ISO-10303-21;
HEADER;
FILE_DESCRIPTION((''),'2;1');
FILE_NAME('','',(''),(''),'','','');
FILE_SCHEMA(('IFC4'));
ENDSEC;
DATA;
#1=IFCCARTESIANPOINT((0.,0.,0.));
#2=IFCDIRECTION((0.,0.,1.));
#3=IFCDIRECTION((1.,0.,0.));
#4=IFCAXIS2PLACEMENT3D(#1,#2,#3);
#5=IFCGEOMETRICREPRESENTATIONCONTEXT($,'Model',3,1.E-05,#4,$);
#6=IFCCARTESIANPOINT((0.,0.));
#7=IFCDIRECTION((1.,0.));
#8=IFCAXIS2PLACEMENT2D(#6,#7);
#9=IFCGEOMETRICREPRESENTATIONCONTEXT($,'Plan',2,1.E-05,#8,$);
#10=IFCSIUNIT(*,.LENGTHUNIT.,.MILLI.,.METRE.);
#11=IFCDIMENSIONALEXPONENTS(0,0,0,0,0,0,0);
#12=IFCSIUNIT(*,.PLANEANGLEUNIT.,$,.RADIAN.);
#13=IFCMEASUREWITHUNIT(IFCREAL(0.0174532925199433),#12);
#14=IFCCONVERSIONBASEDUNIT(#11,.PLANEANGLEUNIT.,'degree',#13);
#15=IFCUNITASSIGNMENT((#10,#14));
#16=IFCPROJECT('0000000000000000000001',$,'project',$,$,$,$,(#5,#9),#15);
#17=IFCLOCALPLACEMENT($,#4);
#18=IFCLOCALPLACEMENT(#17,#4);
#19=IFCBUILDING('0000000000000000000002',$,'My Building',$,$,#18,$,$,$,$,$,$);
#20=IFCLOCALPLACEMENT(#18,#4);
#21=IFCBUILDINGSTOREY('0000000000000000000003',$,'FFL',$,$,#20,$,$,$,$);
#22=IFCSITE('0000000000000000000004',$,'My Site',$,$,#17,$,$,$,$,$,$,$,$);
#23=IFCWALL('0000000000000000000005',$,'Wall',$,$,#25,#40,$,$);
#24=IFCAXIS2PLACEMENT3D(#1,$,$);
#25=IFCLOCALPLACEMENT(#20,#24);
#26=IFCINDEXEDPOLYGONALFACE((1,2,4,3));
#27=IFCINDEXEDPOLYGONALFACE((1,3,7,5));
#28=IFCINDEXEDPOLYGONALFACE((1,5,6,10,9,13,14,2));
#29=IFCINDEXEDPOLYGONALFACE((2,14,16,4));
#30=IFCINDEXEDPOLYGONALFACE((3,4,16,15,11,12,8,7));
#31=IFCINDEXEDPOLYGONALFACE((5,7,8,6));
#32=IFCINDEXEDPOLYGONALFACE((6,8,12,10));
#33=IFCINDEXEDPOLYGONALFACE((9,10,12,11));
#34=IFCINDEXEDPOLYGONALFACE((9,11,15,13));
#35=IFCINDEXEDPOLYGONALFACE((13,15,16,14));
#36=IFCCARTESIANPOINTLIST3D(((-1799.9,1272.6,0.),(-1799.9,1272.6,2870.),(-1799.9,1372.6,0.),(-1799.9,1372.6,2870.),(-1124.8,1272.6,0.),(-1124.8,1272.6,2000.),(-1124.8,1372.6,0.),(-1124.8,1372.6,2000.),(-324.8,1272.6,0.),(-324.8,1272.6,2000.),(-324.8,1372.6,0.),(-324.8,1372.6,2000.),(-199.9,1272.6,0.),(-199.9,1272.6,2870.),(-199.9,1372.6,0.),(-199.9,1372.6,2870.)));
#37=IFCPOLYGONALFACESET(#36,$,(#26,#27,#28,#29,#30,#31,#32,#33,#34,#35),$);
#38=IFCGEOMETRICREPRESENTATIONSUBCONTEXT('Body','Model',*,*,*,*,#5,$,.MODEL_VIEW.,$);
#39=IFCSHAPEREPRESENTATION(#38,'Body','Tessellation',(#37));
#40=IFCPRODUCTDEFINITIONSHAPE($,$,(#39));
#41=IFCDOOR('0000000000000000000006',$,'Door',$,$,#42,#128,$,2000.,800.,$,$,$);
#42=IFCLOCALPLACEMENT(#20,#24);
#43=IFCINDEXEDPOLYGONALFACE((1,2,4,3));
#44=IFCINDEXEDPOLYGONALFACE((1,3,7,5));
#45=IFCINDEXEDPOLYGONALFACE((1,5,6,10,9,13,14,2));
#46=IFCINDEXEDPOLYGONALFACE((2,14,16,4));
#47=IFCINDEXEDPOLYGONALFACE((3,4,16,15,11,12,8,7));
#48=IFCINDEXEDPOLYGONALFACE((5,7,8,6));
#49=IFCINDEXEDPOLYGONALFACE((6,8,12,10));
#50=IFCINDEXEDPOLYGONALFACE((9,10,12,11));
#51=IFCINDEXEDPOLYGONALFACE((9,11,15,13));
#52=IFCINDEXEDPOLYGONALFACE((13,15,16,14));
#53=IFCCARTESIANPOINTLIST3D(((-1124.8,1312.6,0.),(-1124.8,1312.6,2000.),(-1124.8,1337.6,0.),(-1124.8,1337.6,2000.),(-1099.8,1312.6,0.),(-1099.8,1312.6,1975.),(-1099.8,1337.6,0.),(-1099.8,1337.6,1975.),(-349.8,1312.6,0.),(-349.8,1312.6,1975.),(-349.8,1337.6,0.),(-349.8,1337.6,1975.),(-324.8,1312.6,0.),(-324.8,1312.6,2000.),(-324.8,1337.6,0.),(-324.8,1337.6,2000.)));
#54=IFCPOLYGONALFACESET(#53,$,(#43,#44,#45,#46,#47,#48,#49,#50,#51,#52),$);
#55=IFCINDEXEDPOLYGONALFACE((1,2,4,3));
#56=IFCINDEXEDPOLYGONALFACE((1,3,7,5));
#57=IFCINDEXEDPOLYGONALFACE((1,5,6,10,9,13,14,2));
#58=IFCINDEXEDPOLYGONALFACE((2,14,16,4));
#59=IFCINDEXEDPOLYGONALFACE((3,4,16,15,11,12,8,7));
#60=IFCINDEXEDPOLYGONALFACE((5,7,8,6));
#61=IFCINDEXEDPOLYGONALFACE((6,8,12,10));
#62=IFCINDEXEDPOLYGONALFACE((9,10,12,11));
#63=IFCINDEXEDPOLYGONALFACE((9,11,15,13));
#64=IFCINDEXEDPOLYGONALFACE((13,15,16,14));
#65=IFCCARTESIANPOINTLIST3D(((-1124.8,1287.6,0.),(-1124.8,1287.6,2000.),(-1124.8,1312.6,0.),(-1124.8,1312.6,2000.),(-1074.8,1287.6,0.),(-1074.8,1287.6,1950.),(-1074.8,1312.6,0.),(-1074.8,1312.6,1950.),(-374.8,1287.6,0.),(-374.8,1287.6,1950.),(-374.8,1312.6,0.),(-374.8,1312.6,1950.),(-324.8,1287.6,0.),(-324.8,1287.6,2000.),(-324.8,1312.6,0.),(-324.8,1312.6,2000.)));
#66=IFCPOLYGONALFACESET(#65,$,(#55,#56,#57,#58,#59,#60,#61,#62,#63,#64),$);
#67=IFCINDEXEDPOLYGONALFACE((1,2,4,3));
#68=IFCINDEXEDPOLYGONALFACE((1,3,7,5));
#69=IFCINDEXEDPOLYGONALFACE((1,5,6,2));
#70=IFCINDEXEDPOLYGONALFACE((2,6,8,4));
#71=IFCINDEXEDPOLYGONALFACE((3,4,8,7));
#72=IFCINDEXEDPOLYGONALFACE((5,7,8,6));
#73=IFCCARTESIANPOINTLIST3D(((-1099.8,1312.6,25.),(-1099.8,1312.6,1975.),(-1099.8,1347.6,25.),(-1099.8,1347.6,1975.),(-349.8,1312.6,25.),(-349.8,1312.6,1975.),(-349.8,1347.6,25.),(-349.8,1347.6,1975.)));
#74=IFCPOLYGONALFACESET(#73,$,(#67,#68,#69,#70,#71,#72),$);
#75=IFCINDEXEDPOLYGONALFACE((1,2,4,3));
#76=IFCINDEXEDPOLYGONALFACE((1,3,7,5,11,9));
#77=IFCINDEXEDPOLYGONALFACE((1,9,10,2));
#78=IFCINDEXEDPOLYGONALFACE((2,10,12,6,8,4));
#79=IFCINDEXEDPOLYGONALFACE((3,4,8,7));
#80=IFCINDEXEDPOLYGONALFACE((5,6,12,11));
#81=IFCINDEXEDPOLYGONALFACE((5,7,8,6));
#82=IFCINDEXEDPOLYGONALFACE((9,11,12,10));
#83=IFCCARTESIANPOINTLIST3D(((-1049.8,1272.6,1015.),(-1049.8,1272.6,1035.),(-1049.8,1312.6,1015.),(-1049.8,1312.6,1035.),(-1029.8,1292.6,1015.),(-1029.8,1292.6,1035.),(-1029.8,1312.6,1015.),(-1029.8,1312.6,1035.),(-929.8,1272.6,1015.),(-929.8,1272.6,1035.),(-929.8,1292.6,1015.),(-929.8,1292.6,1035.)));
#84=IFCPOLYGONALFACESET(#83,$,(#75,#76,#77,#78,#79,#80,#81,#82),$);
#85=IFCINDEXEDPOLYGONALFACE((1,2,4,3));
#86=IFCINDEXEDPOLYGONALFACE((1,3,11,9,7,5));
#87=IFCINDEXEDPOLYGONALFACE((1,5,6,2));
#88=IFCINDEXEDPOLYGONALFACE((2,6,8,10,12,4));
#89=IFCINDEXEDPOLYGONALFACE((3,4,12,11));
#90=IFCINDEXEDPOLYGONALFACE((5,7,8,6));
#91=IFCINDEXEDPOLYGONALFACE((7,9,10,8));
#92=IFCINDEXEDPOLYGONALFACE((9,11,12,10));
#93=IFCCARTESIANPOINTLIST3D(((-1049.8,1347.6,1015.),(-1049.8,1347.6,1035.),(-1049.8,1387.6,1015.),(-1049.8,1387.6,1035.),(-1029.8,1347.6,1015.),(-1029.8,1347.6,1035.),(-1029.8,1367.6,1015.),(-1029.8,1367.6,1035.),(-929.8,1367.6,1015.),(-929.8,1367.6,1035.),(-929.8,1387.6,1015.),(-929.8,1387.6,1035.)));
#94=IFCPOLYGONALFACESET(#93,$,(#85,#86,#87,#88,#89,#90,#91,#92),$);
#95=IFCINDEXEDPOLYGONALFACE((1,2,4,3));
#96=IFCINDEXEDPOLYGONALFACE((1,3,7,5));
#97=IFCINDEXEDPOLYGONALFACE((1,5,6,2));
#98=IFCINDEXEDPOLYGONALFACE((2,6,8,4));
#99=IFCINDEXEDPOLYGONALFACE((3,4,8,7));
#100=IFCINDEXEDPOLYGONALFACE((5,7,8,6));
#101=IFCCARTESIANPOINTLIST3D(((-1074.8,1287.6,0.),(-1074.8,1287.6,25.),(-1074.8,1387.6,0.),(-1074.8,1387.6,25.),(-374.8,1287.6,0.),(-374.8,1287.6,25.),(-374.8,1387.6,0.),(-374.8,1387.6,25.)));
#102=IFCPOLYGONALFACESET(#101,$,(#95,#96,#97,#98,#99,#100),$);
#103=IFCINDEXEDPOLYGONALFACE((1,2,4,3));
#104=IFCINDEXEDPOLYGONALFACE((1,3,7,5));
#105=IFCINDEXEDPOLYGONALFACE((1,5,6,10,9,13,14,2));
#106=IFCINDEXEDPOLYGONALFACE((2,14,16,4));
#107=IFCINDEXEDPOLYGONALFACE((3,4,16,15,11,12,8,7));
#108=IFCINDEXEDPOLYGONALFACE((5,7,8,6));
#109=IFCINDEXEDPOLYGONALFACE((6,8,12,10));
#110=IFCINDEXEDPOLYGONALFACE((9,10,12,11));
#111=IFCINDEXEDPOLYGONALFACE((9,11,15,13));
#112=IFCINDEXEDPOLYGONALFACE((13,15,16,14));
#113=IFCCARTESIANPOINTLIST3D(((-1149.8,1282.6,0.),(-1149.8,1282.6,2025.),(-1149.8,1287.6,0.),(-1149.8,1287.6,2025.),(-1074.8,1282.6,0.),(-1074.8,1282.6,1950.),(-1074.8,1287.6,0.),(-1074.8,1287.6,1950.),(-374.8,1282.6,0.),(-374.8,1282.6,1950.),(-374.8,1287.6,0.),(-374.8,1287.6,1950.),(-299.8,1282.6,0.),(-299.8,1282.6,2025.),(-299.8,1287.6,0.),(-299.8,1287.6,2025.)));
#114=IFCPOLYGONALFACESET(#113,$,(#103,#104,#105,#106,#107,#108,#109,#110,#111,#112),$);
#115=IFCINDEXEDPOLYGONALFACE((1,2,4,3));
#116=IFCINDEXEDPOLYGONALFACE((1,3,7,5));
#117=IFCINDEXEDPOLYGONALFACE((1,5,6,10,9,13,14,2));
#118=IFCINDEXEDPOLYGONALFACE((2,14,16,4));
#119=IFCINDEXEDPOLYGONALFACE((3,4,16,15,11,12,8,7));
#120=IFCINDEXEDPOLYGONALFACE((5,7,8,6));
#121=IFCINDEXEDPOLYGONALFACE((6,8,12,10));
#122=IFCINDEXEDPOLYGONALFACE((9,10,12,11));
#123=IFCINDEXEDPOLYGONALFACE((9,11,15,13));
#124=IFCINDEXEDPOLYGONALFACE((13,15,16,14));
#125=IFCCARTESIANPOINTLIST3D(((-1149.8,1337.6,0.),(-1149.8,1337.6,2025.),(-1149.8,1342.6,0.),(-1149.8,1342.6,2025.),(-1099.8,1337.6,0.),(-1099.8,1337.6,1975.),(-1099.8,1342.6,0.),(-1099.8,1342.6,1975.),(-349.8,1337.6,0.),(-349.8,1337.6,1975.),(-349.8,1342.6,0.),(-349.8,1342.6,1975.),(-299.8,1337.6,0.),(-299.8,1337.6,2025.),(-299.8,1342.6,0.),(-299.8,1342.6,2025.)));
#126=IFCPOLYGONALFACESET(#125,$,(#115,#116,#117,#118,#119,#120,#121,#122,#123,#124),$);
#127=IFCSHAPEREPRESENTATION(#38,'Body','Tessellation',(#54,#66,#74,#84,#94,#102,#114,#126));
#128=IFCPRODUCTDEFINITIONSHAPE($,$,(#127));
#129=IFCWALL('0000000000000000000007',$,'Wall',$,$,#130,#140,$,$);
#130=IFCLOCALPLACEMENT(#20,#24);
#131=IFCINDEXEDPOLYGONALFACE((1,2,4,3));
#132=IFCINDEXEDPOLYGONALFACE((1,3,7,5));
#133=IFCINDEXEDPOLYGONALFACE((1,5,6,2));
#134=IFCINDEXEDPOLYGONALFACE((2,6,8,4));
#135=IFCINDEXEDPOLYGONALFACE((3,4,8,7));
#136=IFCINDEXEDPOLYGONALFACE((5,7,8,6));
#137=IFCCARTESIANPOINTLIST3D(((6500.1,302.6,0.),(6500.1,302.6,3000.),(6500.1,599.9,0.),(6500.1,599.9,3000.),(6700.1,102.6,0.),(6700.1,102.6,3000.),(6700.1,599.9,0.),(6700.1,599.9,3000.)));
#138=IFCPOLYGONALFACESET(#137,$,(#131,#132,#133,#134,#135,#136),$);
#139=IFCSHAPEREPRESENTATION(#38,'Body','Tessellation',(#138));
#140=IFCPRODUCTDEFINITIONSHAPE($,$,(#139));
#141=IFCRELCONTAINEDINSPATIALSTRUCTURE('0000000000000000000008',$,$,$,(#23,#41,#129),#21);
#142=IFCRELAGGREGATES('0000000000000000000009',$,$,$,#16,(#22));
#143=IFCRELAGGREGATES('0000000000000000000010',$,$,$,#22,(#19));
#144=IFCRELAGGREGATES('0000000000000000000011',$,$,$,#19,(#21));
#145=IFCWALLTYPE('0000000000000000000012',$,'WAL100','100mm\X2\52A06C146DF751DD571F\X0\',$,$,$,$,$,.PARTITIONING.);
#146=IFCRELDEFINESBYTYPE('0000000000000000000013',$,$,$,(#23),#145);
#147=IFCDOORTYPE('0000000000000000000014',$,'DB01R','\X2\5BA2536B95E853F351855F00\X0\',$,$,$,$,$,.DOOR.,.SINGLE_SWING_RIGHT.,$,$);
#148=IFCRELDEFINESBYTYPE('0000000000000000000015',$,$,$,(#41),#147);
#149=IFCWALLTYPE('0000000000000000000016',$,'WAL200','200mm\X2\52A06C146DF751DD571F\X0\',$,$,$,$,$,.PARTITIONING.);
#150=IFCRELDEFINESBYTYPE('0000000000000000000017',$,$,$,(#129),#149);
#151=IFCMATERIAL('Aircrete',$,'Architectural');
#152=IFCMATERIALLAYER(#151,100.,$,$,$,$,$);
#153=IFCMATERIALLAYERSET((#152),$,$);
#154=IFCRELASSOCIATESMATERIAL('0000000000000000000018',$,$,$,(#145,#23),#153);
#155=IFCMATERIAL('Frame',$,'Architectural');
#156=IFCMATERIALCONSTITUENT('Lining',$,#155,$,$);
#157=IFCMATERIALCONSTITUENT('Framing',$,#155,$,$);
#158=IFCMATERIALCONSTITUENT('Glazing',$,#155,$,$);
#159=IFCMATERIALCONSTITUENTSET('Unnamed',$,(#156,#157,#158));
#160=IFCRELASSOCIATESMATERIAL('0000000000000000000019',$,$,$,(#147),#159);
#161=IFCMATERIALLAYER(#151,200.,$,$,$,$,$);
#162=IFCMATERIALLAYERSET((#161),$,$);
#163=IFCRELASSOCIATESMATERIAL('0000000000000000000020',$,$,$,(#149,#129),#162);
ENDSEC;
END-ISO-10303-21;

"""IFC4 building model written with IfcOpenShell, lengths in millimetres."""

from ifc_helpers import new_model, entity, si_unit, converted_unit, frame, origin_with_axes, origin_2d_with_axis, place, context, subcontext, project, spatial, line, indexed_curve, outline, extrude, shape, source, transform, mapped, material, layer, layer_set, layer_usage, constituent, constituent_set, type_object, type_shapes, element, fill, save


model = new_model("IFC4")

# Units and contexts
model_context = context("Model", 3, precision=1e-05, world=origin_with_axes())
plan_context = context("Plan", 2, precision=1e-05, world=origin_2d_with_axis())
body_context_1 = subcontext(model_context, "Body", "Model", "MODEL_VIEW")
body_context_2 = subcontext(plan_context, "Body", "Plan", "PLAN_VIEW")
ifc_project = project(units=[si_unit("LENGTHUNIT", "METRE", prefix="MILLI"), converted_unit("PLANEANGLEUNIT", "degree", entity("IfcReal", 0.0174532925199433), si_unit("PLANEANGLEUNIT", "RADIAN"), dimensions=[0, 0, 0, 0, 0, 0, 0])], contexts=[model_context, plan_context])

# Site, building, storey
site_placement = place(None, origin_with_axes())
site = spatial("IfcSite", under=ifc_project, at=site_placement, Name="My Site")
building_placement = place(site_placement, origin_with_axes())
building = spatial("IfcBuilding", under=site, at=building_placement, Name="My Building")
storey_placement = place(building_placement, origin_with_axes())
storey = spatial("IfcBuildingStorey", under=building, at=storey_placement, Name="FFL")

# Shared definitions
ifc_material_1 = material(Name="Aircrete", Category="Architectural")

# Wall, openings, door
ifc_layer_1 = layer(ifc_material_1, 100.0)
ifc_layer_set_1 = layer_set([ifc_layer_1])
ifc_layer_usage_1 = layer_usage(ifc_layer_set_1, "AXIS2", "POSITIVE", 0.0)
wall_type_1 = type_object("IfcWallType", Name="WAL100", Description="100mm加气混凝土", PredefinedType="PARTITIONING", material=ifc_layer_set_1)
wall_1_placement = place(storey_placement, frame((-199.9, 1372.6, 0.0), z_axis=(0.0, 0.0, 1.0), x_axis=(-1.0, 0.0, 0.0)))
wall_1 = element("IfcWall", 1, at=wall_1_placement, inside=storey, type_object=wall_type_1, material=ifc_layer_usage_1, Name="Wall", context=body_context_1, shape_type="SweptSolid", body=[
    extrude(outline(indexed_curve([(0.0, 0.0), (0.0, 100.0), (1600.0, 100.0), (1600.0, 0.0)], segments=[line(1, 2, 3, 4, 1)])), origin_with_axes(), (0.0, 0.0, 1.0), 2870.0),
])
shared_shape_1 = source(origin_with_axes(), body_context_1, "Body", "SweptSolid", [
    extrude(outline(indexed_curve([(0.0, 0.0), (800.0, 0.0), (800.0, 2000.0), (0.0, 2000.0)], segments=[line(1, 2, 3, 4, 1)])), frame((0.0, -600.0, 0.0), z_axis=(0.0, -1.0, 0.0), x_axis=(1.0, 0.0, 0.0)), (0.0, 0.0, -1.0), 1200.0),
])
opening_1_placement = place(wall_1_placement, frame((924.9, 85.0, 0.0), z_axis=(0.0, 0.0, 1.0), x_axis=(-1.0, 0.0, 0.0)))
opening_1 = element("IfcOpeningElement", 2, at=opening_1_placement, cuts=wall_1, PredefinedType="OPENING", context=body_context_1, shape_type="MappedRepresentation", body=[
    mapped(shared_shape_1, transform((0.0, 0.0, 0.0), x_axis=(1.0, 0.0, 0.0), y_axis=(0.0, 1.0, 0.0), z_axis=(0.0, 0.0, 1.0), scale=1.0)),
])
ifc_material_2 = material(Name="Frame", Category="Architectural")
ifc_constituent_1 = constituent(ifc_material_2, Name="Lining")
ifc_constituent_2 = constituent(ifc_material_2, Name="Framing")
ifc_constituent_3 = constituent(ifc_material_2, Name="Glazing")
ifc_constituent_set_1 = constituent_set(constituents=[ifc_constituent_1, ifc_constituent_2, ifc_constituent_3], Name="Unnamed")
door_type_1 = type_object("IfcDoorType", Name="DB01R", Description="客卫门右内开", OperationType="SINGLE_SWING_RIGHT", PredefinedType="DOOR", material=ifc_constituent_set_1)
shared_shape_2 = source(origin_with_axes(), body_context_1, "Body", "SweptSolid", [
    extrude(outline(indexed_curve([(0.0, 0.0), (0.0, 2000.0), (800.0, 2000.0), (800.0, 0.0), (775.0, 0.0), (775.0, 1975.0), (25.0, 1975.0), (25.0, 0.0)], segments=[line(1, 2, 3, 4, 5, 6, 7, 8, 1)])), frame((0.0, 25.0, 0.0), z_axis=(0.0, -1.0, 0.0), x_axis=(1.0, 0.0, 0.0)), (0.0, 0.0, -1.0), 25.0),
    extrude(outline(indexed_curve([(0.0, 0.0), (0.0, 2000.0), (800.0, 2000.0), (800.0, 0.0), (750.0, 0.0), (750.0, 1950.0), (50.0, 1950.0), (50.0, 0.0)], segments=[line(1, 2, 3, 4, 5, 6, 7, 8, 1)])), frame((0.0, 0.0, 0.0), z_axis=(0.0, -1.0, 0.0), x_axis=(1.0, 0.0, 0.0)), (0.0, 0.0, -1.0), 25.0),
    extrude(outline(indexed_curve([(0.0, 0.0), (750.0, 0.0), (750.0, 35.0), (0.0, 35.0)], segments=[line(1, 2, 3, 4, 1)])), frame((25.0, 25.0, 25.0), z_axis=(0.0, 0.0, 1.0), x_axis=(1.0, 0.0, 0.0)), (0.0, 0.0, 1.0), 1950.0),
    extrude(outline(indexed_curve([(0.0, 0.0), (0.0, -40.0), (120.0, -40.0), (120.0, -20.0), (20.0, -20.0), (20.0, 0.0)], segments=[line(1, 2, 3, 4, 5, 6, 1)])), frame((75.0, 25.0, 1015.0), z_axis=(0.0, 0.0, 1.0), x_axis=(1.0, 0.0, 0.0)), (0.0, 0.0, 1.0), 20.0),
    extrude(outline(indexed_curve([(0.0, 0.0), (0.0, 40.0), (120.0, 40.0), (120.0, 20.0), (20.0, 20.0), (20.0, 0.0)], segments=[line(1, 2, 3, 4, 5, 6, 1)])), frame((75.0, 60.0, 1015.0), z_axis=(0.0, 0.0, 1.0), x_axis=(1.0, 0.0, 0.0)), (0.0, 0.0, 1.0), 20.0),
    extrude(outline(indexed_curve([(0.0, 0.0), (700.0, 0.0), (700.0, 100.0), (0.0, 100.0)], segments=[line(1, 2, 3, 4, 1)])), frame((50.0, 0.0, 0.0), z_axis=(0.0, 0.0, 1.0), x_axis=(1.0, 0.0, 0.0)), (0.0, 0.0, 1.0), 25.0),
    extrude(outline(indexed_curve([(0.0, 0.0), (0.0, 2025.0), (850.0, 2025.0), (850.0, 0.0), (775.0, 0.0), (775.0, 1950.0), (75.0, 1950.0), (75.0, 0.0)], segments=[line(1, 2, 3, 4, 5, 6, 7, 8, 1)])), frame((-25.0, -5.0, 0.0), z_axis=(0.0, -1.0, 0.0), x_axis=(1.0, 0.0, 0.0)), (0.0, 0.0, -1.0), 5.0),
    extrude(outline(indexed_curve([(0.0, 0.0), (0.0, 2025.0), (850.0, 2025.0), (850.0, 0.0), (800.0, 0.0), (800.0, 1975.0), (50.0, 1975.0), (50.0, 0.0)], segments=[line(1, 2, 3, 4, 5, 6, 7, 8, 1)])), frame((-25.0, 50.0, 0.0), z_axis=(0.0, -1.0, 0.0), x_axis=(1.0, 0.0, 0.0)), (0.0, 0.0, -1.0), 5.0),
])
shared_shape_3 = source(origin_with_axes(), body_context_2, "Body", "Curve2D", [
    entity("IfcIndexedPolyCurve", entity("IfcCartesianPointList2D", [[0.0, 0.0], [0.0, 50.0], [25.0, 50.0], [25.0, 25.0], [50.0, 25.0], [50.0, 0.0]]), [entity("IfcLineIndex", [1, 2, 3, 4, 5, 6, 1])]),
    entity("IfcIndexedPolyCurve", entity("IfcCartesianPointList2D", [[800.0, 0.0], [800.0, 50.0], [775.0, 50.0], [775.0, 25.0], [750.0, 25.0], [750.0, 0.0]]), [entity("IfcLineIndex", [1, 2, 3, 4, 5, 6, 1])]),
    entity("IfcTrimmedCurve", entity("IfcEllipse", entity("IfcAxis2Placement2D", entity("IfcCartesianPoint", [740.0, 50.0]), entity("IfcDirection", [1.0, 0.0])), 715.0, 750.0), [entity("IfcCartesianPoint", [740.0, 800.0])], [entity("IfcCartesianPoint", [25.0, 50.0])], True, "CARTESIAN"),
    entity("IfcIndexedPolyCurve", entity("IfcCartesianPointList2D", [[775.0, 50.0], [740.0, 50.0], [740.0, 800.0], [775.0, 800.0]]), [entity("IfcLineIndex", [1, 2, 3, 4, 1])]),
])
type_shapes(door_type_1, [shared_shape_2, shared_shape_3])
door_1_placement = place(opening_1_placement, frame((0.0, 0.0, 0.0), z_axis=(0.0, 0.0, 1.0), x_axis=(1.0, 0.0, 0.0)))
door_1 = element("IfcDoor", 3, at=door_1_placement, inside=storey, type_object=door_type_1, Name="Door", OverallHeight=2000.0, OverallWidth=800.0, shapes=[
    shape(body_context_1, "Body", "MappedRepresentation", [mapped(shared_shape_2, transform((0.0, 0.0, 0.0), x_axis=(1.0, 0.0, 0.0), y_axis=(0.0, 1.0, 0.0), z_axis=(0.0, 0.0, 1.0), scale=1.0))]),
    shape(body_context_2, "Body", "MappedRepresentation", [mapped(shared_shape_3, transform((0.0, 0.0, 0.0), x_axis=(1.0, 0.0, 0.0), y_axis=(0.0, 1.0, 0.0), z_axis=(0.0, 0.0, 1.0), scale=1.0))]),
])
fill(opening_1, door_1)
opening_2_placement = place(door_1_placement, frame((1600.1, 1172.5, 0.0), z_axis=(0.0, 0.0, 1.0), x_axis=(-1.0, 0.0, 0.0)))
element("IfcOpeningElement", 4, at=opening_2_placement, cuts=door_1, PredefinedType="OPENING", context=body_context_1, shape_type="SweptSolid", body=[
    extrude(outline(indexed_curve([(0.0, 0.0), (500.0, 0.0), (500.0, 500.0), (0.0, 500.0)], segments=[line(1, 2, 3, 4, 1)])), origin_with_axes(), (0.0, 0.0, 1.0), 500.0),
])

# Shared definitions
ifc_layer_2 = layer(ifc_material_1, 200.0)
ifc_layer_set_2 = layer_set([ifc_layer_2])
wall_type_2 = type_object("IfcWallType", Name="WAL200", Description="200mm加气混凝土", PredefinedType="PARTITIONING", material=ifc_layer_set_2)

# Wall
ifc_layer_usage_2 = layer_usage(ifc_layer_set_2, "AXIS2", "NEGATIVE", 0.0)
wall_2_placement = place(storey_placement, frame((6700.1, 599.9, 0.0), z_axis=(0.0, 0.0, 1.0), x_axis=(-0.000001, -1.0, 0.0)))
element("IfcWall", 5, at=wall_2_placement, inside=storey, type_object=wall_type_2, material=ifc_layer_usage_2, Name="Wall", context=body_context_1, shape_type="SweptSolid", body=[
    extrude(outline(indexed_curve([(0.0, -200.0), (0.0, 0.0), (497.3, 0.0), (297.3, -200.0)], segments=[line(1, 2, 3, 4, 1)])), origin_with_axes(), (0.0, 0.0, 1.0), 3000.0),
])

save(model, "model.ifc")
